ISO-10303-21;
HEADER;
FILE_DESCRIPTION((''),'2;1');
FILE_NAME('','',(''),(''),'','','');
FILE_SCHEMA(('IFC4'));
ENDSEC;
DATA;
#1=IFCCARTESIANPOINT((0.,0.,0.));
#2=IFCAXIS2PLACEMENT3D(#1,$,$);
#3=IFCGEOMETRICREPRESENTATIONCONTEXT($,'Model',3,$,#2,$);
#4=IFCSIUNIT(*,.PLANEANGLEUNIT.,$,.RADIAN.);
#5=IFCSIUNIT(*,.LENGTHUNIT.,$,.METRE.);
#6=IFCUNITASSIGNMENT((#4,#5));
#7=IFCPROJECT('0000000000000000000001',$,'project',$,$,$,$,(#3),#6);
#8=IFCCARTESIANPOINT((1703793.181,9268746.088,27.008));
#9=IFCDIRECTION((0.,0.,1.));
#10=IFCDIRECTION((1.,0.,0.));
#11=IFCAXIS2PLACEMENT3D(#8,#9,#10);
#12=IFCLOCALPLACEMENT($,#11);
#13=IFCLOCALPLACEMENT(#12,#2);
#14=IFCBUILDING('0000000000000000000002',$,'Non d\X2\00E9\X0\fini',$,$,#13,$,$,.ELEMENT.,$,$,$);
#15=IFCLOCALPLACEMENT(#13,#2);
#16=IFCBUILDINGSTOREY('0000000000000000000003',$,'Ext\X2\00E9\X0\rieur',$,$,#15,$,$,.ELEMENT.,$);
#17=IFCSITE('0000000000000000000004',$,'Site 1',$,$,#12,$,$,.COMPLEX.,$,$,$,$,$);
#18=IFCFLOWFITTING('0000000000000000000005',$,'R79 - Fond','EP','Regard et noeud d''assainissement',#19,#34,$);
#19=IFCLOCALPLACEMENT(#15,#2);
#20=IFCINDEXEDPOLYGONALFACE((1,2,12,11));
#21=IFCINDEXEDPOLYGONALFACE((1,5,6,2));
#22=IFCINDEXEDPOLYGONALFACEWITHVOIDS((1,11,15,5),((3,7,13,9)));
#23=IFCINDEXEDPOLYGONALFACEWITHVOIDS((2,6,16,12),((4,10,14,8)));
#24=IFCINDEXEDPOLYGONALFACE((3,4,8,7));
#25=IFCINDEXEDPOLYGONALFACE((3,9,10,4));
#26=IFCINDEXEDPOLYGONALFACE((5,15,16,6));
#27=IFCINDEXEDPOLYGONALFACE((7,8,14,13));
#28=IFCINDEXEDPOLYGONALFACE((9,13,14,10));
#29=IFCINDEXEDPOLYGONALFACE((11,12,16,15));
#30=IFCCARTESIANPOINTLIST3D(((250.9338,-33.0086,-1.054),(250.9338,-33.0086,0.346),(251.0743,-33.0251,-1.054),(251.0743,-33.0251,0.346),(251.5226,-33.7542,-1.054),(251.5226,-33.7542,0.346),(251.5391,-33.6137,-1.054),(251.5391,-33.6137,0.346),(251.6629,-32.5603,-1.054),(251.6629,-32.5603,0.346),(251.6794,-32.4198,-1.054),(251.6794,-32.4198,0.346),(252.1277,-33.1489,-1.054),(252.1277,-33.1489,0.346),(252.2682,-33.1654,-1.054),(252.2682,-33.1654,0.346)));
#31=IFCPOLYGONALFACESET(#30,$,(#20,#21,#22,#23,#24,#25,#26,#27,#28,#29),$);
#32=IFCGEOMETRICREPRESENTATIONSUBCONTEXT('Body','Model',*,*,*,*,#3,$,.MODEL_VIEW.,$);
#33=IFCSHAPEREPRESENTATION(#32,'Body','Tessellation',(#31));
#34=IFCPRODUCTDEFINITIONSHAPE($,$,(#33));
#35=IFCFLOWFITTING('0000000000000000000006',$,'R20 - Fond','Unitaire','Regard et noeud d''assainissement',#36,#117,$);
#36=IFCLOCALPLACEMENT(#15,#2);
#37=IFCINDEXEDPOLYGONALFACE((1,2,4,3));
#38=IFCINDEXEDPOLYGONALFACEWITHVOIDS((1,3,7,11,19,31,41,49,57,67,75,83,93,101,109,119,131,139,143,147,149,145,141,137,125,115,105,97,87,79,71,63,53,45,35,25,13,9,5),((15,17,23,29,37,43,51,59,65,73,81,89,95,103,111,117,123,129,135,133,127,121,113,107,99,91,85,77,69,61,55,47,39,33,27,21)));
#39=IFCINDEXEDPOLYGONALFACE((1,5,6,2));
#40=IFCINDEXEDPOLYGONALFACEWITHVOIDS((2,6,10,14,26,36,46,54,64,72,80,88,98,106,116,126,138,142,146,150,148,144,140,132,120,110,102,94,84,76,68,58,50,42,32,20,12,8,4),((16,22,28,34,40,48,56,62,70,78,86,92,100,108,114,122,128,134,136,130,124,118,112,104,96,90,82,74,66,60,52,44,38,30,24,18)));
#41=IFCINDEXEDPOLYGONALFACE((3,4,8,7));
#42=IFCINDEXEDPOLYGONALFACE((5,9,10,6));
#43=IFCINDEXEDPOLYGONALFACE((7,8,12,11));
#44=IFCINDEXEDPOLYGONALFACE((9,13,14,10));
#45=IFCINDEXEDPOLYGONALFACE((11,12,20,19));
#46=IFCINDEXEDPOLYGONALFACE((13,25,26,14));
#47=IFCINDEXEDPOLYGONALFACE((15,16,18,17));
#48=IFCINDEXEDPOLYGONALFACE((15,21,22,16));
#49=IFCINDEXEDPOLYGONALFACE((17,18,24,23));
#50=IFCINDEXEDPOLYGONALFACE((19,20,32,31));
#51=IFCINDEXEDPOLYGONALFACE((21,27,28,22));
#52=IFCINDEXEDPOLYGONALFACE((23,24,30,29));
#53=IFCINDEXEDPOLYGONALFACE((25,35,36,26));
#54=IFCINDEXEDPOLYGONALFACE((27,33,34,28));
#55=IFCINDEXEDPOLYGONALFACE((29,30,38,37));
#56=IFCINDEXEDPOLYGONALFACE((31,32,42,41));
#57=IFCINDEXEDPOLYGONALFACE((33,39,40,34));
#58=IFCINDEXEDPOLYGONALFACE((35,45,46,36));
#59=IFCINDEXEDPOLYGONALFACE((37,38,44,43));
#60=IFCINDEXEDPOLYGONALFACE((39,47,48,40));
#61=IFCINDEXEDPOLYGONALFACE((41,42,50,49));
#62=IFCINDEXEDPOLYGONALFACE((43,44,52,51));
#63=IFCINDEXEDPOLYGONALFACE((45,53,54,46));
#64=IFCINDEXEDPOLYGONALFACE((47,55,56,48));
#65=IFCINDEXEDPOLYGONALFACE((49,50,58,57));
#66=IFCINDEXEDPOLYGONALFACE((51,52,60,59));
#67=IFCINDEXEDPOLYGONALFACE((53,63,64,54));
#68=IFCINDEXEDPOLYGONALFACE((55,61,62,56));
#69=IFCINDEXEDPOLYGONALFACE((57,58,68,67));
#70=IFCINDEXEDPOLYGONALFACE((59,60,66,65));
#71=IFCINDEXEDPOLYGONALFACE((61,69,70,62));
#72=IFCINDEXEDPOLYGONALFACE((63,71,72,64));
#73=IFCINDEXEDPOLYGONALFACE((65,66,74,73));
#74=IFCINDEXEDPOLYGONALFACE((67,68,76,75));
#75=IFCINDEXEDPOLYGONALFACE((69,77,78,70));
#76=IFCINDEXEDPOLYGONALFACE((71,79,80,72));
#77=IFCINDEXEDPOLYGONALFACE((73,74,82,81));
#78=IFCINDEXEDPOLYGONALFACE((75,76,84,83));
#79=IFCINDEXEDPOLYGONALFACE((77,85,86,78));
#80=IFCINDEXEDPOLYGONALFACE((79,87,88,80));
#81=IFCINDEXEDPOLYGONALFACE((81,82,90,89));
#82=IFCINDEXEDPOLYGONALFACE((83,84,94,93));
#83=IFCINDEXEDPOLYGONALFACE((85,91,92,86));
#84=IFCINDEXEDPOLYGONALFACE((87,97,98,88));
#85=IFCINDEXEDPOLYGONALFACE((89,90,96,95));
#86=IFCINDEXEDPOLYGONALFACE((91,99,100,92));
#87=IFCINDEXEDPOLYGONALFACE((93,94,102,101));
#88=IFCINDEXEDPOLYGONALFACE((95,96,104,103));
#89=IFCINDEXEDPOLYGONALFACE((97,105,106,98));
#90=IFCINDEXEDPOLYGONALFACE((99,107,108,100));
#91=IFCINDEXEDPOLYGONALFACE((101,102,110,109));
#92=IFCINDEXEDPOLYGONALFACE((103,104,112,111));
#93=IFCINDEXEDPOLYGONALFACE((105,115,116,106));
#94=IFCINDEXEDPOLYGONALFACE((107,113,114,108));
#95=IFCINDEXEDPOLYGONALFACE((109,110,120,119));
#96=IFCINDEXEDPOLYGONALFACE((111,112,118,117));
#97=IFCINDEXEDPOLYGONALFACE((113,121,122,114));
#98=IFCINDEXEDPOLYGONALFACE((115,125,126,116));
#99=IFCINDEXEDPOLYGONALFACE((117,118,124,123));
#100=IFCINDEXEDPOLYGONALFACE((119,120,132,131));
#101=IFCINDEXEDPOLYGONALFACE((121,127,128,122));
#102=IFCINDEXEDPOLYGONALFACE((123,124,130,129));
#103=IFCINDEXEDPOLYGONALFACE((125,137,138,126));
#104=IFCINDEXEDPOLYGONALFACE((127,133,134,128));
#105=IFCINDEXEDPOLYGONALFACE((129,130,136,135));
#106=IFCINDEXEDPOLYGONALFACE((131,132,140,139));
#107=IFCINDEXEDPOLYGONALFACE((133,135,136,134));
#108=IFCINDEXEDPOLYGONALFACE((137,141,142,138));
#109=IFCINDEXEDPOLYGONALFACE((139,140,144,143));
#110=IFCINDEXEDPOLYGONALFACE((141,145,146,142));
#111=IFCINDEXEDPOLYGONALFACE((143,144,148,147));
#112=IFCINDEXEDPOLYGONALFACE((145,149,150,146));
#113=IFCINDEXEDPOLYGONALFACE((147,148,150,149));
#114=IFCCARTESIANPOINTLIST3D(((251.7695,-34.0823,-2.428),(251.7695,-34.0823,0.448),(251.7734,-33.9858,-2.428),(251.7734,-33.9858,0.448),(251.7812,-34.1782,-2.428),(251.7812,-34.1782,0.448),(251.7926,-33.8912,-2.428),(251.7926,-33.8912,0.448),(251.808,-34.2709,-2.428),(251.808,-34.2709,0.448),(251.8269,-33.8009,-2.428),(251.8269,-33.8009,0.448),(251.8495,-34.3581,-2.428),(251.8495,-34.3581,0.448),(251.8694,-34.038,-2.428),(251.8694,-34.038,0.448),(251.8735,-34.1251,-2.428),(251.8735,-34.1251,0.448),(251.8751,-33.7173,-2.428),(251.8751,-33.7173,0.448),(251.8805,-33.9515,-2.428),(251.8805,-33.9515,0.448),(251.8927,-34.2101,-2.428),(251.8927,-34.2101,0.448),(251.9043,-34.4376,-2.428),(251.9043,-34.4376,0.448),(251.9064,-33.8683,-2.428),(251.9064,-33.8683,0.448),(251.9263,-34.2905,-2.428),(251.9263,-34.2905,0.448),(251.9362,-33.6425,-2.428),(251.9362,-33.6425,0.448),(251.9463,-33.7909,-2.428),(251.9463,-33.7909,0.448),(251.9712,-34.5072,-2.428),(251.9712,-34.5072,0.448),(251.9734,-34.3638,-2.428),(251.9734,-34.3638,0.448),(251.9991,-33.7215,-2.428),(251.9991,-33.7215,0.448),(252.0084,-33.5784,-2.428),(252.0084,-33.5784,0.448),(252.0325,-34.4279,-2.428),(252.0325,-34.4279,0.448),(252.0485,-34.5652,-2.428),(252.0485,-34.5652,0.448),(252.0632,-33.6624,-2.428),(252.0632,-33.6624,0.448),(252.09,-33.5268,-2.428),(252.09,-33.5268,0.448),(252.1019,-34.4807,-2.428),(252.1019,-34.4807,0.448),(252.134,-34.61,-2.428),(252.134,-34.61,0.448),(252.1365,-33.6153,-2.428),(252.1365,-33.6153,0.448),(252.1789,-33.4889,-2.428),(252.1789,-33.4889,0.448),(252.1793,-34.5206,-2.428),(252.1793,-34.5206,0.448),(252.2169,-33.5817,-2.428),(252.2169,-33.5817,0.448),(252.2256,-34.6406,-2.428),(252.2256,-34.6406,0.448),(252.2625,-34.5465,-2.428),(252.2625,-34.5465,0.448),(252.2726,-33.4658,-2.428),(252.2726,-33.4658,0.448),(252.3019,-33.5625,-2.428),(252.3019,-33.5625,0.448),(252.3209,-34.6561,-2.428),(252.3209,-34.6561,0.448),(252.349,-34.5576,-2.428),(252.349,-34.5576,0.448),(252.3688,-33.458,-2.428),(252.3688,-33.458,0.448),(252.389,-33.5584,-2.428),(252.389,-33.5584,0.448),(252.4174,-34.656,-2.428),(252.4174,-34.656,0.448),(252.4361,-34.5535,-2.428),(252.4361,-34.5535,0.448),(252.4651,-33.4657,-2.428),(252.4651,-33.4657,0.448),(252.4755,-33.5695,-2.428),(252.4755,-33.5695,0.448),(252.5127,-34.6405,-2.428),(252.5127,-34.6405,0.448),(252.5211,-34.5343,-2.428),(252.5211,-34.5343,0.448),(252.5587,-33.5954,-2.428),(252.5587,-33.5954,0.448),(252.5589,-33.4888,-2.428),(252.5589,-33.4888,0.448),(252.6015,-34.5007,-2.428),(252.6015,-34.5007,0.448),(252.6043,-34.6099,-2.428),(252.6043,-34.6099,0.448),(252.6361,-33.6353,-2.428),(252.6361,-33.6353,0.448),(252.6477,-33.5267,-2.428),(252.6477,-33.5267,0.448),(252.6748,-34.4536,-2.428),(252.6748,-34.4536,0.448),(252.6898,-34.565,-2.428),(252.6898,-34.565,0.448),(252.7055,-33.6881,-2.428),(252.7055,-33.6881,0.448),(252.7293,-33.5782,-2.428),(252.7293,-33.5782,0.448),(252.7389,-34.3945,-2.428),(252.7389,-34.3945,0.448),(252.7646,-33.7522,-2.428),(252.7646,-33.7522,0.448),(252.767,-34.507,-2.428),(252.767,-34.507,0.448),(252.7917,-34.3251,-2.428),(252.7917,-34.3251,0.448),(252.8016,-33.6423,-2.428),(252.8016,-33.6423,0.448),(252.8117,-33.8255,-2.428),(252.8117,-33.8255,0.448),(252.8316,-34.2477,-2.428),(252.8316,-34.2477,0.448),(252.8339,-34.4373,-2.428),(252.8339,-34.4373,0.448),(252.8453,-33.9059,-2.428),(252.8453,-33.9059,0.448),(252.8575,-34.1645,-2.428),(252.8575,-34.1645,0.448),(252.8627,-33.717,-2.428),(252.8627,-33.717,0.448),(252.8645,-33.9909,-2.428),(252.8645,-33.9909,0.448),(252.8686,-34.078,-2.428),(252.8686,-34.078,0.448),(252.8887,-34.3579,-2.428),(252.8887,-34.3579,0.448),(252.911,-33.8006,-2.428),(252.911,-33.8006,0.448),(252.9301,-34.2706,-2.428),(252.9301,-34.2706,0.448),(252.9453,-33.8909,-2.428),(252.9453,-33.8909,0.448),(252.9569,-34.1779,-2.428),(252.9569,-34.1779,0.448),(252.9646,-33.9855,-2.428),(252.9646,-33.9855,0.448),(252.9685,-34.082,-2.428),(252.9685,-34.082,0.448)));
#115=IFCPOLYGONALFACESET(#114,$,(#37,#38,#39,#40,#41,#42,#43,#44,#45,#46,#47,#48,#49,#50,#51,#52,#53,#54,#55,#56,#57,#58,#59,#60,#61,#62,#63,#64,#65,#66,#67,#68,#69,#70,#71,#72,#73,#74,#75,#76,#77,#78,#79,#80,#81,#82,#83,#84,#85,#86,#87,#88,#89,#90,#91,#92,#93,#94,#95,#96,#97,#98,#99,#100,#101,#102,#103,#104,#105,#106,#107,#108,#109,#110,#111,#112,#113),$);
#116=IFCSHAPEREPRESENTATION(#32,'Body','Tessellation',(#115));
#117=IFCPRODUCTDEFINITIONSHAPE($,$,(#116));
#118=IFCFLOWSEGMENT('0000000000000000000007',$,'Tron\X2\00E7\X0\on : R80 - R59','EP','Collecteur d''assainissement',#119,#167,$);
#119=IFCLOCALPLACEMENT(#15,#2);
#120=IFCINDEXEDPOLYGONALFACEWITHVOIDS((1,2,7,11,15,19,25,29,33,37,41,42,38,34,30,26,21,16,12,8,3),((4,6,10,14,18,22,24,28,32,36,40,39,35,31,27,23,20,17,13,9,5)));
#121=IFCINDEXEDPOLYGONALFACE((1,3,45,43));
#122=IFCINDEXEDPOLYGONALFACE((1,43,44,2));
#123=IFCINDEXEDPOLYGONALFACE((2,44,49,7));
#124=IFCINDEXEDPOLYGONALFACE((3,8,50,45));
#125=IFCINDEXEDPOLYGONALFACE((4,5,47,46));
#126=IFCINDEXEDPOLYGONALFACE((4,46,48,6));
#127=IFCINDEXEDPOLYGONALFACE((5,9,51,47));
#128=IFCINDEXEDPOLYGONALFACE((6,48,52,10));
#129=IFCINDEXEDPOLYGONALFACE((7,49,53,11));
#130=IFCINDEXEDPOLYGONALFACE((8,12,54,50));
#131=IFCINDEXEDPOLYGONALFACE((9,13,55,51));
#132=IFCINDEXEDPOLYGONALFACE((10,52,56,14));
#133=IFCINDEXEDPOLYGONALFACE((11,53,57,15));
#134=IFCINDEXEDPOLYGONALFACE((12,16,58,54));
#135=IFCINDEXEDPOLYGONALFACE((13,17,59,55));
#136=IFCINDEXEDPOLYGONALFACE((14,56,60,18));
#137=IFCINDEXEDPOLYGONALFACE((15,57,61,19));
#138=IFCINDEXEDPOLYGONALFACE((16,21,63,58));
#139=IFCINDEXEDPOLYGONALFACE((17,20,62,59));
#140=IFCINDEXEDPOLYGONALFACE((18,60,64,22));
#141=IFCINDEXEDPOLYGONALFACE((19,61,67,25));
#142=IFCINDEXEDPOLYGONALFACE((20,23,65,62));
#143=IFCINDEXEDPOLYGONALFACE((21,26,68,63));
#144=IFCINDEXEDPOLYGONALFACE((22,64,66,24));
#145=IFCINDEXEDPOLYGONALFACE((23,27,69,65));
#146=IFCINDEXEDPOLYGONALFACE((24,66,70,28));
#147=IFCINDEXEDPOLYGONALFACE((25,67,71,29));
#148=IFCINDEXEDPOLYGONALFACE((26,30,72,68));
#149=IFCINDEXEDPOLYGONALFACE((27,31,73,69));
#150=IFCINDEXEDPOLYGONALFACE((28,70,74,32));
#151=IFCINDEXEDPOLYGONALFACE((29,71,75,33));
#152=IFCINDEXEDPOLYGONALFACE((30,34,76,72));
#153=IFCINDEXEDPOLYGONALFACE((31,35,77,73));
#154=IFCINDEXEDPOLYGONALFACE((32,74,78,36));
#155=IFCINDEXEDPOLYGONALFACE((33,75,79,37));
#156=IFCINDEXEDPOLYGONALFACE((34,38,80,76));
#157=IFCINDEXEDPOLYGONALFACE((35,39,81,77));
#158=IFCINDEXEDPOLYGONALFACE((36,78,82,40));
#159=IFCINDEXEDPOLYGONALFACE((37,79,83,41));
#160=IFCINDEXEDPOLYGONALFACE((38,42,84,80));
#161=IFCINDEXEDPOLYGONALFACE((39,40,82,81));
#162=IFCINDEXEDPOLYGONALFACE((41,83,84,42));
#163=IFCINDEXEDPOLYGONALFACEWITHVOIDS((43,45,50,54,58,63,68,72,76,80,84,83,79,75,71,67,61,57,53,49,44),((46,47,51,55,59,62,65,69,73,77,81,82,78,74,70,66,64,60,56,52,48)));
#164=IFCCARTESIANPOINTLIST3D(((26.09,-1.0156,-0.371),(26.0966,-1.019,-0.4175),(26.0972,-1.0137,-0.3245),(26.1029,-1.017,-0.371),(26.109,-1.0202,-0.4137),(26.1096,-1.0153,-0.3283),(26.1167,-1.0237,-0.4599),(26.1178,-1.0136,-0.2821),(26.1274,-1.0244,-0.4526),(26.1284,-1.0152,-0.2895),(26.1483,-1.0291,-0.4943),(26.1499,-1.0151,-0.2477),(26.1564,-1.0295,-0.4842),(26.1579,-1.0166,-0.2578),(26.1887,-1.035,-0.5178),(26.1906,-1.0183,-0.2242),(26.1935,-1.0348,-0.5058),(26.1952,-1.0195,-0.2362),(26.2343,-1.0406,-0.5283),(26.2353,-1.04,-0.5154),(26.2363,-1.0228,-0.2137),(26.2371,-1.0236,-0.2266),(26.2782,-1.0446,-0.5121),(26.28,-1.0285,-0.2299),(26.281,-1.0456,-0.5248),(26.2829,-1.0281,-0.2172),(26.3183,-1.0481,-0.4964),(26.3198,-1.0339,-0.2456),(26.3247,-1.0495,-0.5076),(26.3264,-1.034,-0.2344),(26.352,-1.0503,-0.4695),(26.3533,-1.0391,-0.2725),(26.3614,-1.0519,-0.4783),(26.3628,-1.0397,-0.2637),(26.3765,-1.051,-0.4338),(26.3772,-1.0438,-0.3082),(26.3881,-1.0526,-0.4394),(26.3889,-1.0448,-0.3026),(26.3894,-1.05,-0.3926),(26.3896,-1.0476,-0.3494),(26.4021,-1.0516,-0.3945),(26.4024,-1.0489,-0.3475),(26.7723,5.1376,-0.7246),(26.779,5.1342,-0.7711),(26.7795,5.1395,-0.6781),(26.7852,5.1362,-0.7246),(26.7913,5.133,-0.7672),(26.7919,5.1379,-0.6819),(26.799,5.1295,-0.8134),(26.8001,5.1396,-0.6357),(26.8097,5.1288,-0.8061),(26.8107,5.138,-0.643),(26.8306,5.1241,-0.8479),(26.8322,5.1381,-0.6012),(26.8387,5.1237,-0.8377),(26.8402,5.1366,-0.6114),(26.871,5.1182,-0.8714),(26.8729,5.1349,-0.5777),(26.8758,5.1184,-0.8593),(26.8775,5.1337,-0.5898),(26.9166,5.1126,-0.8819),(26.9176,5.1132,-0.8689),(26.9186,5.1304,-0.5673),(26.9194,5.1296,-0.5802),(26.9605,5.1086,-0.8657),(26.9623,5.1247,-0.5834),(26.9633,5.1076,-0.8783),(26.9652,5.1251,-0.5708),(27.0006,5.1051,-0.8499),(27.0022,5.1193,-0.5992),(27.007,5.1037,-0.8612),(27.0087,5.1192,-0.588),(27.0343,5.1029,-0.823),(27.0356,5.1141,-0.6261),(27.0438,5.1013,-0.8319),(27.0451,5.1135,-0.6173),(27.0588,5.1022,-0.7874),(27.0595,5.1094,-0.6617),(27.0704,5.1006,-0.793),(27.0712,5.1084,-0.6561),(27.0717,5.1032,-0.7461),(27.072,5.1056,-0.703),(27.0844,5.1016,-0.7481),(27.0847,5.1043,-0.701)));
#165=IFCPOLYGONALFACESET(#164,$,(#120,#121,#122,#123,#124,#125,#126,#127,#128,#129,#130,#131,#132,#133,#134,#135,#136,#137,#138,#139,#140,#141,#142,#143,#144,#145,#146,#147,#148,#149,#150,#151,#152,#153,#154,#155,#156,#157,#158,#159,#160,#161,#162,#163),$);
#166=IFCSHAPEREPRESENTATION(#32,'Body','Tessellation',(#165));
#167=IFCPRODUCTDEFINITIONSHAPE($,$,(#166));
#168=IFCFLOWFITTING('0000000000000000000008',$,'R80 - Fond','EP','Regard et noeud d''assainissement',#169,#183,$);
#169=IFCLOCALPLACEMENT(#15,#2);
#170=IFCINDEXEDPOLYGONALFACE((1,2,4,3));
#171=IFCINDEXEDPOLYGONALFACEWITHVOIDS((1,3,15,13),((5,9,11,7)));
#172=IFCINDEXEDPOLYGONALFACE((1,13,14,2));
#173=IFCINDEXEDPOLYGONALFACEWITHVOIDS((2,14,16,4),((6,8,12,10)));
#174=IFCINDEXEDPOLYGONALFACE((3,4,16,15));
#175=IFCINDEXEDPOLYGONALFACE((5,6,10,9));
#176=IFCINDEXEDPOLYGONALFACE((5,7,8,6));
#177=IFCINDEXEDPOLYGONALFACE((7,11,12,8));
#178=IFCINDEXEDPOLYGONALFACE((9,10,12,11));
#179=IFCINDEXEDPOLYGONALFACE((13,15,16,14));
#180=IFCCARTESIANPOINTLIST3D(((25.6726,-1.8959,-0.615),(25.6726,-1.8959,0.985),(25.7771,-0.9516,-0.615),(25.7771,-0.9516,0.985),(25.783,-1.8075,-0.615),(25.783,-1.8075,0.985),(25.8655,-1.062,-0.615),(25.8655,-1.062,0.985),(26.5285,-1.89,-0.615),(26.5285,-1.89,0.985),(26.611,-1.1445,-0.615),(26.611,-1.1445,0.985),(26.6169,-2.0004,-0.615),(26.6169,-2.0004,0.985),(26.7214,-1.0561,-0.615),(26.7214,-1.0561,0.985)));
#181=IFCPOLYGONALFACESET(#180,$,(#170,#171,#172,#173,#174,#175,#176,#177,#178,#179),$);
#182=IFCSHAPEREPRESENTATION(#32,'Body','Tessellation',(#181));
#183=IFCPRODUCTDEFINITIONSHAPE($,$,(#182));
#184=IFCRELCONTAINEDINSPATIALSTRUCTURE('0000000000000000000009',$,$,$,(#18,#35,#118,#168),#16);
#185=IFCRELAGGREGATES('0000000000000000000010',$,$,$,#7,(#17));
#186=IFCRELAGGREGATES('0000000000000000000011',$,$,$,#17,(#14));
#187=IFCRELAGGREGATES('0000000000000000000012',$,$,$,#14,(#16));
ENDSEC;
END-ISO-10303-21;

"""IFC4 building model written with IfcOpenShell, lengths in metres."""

from ifc_helpers import new_model, si_unit, frame, origin, origin_2d, place, context, subcontext, project, spatial, hollow_rectangle, hollow_circle, extrude, element, save


model = new_model("IFC4")

# Units and contexts
model_context = context("Model", 3, world=origin())
body_context = subcontext(model_context, "Body", "Model", "MODEL_VIEW")
ifc_project = project(units=[si_unit("PLANEANGLEUNIT", "RADIAN"), si_unit("LENGTHUNIT", "METRE")], contexts=[model_context])

# Site, building, storey
site_placement = place(None, frame((1703793.181, 9268746.088, 27.008), z_axis=(0.0, 0.0, 1.0), x_axis=(1.0, 0.0, 0.0)))
site = spatial("IfcSite", under=ifc_project, at=site_placement, Name="Site 1", CompositionType="COMPLEX")
building_placement = place(site_placement, origin())
building = spatial("IfcBuilding", under=site, at=building_placement, Name="Non défini", CompositionType="ELEMENT")
storey_placement = place(building_placement, origin())
storey = spatial("IfcBuildingStorey", under=building, at=storey_placement, Name="Extérieur", CompositionType="ELEMENT")

# Flow fittings
flow_fitting_1_placement = place(storey_placement, origin())
element("IfcFlowFitting", 1, at=flow_fitting_1_placement, inside=storey, Name="R79 - Fond", Description="EP", ObjectType="Regard et noeud d'assainissement", context=body_context, shape_type="SweptSolid", body=[
    extrude(hollow_rectangle(XDim=0.95, YDim=0.95, WallThickness=0.1, at=origin_2d()), frame((251.601, -33.087, -1.054), z_axis=(0.0, 0.0, 1.0), x_axis=(0.62, -0.785, 0.0)), (0.0, 0.0, 1.0), 1.4),
])
flow_fitting_2_placement = place(storey_placement, origin())
element("IfcFlowFitting", 2, at=flow_fitting_2_placement, inside=storey, Name="R20 - Fond", Description="Unitaire", ObjectType="Regard et noeud d'assainissement", context=body_context, shape_type="SweptSolid", body=[
    extrude(hollow_circle(Radius=0.6, WallThickness=0.1, at=origin_2d()), frame((252.369, -34.058, -2.428), z_axis=(0.0, 0.0, 1.0), x_axis=(0.999, -0.04, 0.0)), (0.0, 0.0, 1.0), 2.876),
])

# Flow segment
flow_segment_1_placement = place(storey_placement, origin())
element("IfcFlowSegment", 3, at=flow_segment_1_placement, inside=storey, Name="Tronçon : R80 - R59", Description="EP", ObjectType="Collecteur d'assainissement", context=body_context, shape_type="SweptSolid", body=[
    extrude(hollow_circle(Radius=0.158, WallThickness=0.013, at=origin_2d()), frame((26.247, -1.033, -0.371), z_axis=(0.11, 0.992, -0.057), x_axis=(-0.994, 0.11, 0.0)), (0.0, 0.0, 1.0), 6.201),
])

# Flow fitting
flow_fitting_3_placement = place(storey_placement, origin())
element("IfcFlowFitting", 4, at=flow_fitting_3_placement, inside=storey, Name="R80 - Fond", Description="EP", ObjectType="Regard et noeud d'assainissement", context=body_context, shape_type="SweptSolid", body=[
    extrude(hollow_rectangle(XDim=0.95, YDim=0.95, WallThickness=0.1, at=origin_2d()), frame((26.197, -1.476, -0.615), z_axis=(0.0, 0.0, 1.0), x_axis=(0.11, 0.994, 0.0)), (0.0, 0.0, 1.0), 1.6),
])

save(model, "model.ifc")
